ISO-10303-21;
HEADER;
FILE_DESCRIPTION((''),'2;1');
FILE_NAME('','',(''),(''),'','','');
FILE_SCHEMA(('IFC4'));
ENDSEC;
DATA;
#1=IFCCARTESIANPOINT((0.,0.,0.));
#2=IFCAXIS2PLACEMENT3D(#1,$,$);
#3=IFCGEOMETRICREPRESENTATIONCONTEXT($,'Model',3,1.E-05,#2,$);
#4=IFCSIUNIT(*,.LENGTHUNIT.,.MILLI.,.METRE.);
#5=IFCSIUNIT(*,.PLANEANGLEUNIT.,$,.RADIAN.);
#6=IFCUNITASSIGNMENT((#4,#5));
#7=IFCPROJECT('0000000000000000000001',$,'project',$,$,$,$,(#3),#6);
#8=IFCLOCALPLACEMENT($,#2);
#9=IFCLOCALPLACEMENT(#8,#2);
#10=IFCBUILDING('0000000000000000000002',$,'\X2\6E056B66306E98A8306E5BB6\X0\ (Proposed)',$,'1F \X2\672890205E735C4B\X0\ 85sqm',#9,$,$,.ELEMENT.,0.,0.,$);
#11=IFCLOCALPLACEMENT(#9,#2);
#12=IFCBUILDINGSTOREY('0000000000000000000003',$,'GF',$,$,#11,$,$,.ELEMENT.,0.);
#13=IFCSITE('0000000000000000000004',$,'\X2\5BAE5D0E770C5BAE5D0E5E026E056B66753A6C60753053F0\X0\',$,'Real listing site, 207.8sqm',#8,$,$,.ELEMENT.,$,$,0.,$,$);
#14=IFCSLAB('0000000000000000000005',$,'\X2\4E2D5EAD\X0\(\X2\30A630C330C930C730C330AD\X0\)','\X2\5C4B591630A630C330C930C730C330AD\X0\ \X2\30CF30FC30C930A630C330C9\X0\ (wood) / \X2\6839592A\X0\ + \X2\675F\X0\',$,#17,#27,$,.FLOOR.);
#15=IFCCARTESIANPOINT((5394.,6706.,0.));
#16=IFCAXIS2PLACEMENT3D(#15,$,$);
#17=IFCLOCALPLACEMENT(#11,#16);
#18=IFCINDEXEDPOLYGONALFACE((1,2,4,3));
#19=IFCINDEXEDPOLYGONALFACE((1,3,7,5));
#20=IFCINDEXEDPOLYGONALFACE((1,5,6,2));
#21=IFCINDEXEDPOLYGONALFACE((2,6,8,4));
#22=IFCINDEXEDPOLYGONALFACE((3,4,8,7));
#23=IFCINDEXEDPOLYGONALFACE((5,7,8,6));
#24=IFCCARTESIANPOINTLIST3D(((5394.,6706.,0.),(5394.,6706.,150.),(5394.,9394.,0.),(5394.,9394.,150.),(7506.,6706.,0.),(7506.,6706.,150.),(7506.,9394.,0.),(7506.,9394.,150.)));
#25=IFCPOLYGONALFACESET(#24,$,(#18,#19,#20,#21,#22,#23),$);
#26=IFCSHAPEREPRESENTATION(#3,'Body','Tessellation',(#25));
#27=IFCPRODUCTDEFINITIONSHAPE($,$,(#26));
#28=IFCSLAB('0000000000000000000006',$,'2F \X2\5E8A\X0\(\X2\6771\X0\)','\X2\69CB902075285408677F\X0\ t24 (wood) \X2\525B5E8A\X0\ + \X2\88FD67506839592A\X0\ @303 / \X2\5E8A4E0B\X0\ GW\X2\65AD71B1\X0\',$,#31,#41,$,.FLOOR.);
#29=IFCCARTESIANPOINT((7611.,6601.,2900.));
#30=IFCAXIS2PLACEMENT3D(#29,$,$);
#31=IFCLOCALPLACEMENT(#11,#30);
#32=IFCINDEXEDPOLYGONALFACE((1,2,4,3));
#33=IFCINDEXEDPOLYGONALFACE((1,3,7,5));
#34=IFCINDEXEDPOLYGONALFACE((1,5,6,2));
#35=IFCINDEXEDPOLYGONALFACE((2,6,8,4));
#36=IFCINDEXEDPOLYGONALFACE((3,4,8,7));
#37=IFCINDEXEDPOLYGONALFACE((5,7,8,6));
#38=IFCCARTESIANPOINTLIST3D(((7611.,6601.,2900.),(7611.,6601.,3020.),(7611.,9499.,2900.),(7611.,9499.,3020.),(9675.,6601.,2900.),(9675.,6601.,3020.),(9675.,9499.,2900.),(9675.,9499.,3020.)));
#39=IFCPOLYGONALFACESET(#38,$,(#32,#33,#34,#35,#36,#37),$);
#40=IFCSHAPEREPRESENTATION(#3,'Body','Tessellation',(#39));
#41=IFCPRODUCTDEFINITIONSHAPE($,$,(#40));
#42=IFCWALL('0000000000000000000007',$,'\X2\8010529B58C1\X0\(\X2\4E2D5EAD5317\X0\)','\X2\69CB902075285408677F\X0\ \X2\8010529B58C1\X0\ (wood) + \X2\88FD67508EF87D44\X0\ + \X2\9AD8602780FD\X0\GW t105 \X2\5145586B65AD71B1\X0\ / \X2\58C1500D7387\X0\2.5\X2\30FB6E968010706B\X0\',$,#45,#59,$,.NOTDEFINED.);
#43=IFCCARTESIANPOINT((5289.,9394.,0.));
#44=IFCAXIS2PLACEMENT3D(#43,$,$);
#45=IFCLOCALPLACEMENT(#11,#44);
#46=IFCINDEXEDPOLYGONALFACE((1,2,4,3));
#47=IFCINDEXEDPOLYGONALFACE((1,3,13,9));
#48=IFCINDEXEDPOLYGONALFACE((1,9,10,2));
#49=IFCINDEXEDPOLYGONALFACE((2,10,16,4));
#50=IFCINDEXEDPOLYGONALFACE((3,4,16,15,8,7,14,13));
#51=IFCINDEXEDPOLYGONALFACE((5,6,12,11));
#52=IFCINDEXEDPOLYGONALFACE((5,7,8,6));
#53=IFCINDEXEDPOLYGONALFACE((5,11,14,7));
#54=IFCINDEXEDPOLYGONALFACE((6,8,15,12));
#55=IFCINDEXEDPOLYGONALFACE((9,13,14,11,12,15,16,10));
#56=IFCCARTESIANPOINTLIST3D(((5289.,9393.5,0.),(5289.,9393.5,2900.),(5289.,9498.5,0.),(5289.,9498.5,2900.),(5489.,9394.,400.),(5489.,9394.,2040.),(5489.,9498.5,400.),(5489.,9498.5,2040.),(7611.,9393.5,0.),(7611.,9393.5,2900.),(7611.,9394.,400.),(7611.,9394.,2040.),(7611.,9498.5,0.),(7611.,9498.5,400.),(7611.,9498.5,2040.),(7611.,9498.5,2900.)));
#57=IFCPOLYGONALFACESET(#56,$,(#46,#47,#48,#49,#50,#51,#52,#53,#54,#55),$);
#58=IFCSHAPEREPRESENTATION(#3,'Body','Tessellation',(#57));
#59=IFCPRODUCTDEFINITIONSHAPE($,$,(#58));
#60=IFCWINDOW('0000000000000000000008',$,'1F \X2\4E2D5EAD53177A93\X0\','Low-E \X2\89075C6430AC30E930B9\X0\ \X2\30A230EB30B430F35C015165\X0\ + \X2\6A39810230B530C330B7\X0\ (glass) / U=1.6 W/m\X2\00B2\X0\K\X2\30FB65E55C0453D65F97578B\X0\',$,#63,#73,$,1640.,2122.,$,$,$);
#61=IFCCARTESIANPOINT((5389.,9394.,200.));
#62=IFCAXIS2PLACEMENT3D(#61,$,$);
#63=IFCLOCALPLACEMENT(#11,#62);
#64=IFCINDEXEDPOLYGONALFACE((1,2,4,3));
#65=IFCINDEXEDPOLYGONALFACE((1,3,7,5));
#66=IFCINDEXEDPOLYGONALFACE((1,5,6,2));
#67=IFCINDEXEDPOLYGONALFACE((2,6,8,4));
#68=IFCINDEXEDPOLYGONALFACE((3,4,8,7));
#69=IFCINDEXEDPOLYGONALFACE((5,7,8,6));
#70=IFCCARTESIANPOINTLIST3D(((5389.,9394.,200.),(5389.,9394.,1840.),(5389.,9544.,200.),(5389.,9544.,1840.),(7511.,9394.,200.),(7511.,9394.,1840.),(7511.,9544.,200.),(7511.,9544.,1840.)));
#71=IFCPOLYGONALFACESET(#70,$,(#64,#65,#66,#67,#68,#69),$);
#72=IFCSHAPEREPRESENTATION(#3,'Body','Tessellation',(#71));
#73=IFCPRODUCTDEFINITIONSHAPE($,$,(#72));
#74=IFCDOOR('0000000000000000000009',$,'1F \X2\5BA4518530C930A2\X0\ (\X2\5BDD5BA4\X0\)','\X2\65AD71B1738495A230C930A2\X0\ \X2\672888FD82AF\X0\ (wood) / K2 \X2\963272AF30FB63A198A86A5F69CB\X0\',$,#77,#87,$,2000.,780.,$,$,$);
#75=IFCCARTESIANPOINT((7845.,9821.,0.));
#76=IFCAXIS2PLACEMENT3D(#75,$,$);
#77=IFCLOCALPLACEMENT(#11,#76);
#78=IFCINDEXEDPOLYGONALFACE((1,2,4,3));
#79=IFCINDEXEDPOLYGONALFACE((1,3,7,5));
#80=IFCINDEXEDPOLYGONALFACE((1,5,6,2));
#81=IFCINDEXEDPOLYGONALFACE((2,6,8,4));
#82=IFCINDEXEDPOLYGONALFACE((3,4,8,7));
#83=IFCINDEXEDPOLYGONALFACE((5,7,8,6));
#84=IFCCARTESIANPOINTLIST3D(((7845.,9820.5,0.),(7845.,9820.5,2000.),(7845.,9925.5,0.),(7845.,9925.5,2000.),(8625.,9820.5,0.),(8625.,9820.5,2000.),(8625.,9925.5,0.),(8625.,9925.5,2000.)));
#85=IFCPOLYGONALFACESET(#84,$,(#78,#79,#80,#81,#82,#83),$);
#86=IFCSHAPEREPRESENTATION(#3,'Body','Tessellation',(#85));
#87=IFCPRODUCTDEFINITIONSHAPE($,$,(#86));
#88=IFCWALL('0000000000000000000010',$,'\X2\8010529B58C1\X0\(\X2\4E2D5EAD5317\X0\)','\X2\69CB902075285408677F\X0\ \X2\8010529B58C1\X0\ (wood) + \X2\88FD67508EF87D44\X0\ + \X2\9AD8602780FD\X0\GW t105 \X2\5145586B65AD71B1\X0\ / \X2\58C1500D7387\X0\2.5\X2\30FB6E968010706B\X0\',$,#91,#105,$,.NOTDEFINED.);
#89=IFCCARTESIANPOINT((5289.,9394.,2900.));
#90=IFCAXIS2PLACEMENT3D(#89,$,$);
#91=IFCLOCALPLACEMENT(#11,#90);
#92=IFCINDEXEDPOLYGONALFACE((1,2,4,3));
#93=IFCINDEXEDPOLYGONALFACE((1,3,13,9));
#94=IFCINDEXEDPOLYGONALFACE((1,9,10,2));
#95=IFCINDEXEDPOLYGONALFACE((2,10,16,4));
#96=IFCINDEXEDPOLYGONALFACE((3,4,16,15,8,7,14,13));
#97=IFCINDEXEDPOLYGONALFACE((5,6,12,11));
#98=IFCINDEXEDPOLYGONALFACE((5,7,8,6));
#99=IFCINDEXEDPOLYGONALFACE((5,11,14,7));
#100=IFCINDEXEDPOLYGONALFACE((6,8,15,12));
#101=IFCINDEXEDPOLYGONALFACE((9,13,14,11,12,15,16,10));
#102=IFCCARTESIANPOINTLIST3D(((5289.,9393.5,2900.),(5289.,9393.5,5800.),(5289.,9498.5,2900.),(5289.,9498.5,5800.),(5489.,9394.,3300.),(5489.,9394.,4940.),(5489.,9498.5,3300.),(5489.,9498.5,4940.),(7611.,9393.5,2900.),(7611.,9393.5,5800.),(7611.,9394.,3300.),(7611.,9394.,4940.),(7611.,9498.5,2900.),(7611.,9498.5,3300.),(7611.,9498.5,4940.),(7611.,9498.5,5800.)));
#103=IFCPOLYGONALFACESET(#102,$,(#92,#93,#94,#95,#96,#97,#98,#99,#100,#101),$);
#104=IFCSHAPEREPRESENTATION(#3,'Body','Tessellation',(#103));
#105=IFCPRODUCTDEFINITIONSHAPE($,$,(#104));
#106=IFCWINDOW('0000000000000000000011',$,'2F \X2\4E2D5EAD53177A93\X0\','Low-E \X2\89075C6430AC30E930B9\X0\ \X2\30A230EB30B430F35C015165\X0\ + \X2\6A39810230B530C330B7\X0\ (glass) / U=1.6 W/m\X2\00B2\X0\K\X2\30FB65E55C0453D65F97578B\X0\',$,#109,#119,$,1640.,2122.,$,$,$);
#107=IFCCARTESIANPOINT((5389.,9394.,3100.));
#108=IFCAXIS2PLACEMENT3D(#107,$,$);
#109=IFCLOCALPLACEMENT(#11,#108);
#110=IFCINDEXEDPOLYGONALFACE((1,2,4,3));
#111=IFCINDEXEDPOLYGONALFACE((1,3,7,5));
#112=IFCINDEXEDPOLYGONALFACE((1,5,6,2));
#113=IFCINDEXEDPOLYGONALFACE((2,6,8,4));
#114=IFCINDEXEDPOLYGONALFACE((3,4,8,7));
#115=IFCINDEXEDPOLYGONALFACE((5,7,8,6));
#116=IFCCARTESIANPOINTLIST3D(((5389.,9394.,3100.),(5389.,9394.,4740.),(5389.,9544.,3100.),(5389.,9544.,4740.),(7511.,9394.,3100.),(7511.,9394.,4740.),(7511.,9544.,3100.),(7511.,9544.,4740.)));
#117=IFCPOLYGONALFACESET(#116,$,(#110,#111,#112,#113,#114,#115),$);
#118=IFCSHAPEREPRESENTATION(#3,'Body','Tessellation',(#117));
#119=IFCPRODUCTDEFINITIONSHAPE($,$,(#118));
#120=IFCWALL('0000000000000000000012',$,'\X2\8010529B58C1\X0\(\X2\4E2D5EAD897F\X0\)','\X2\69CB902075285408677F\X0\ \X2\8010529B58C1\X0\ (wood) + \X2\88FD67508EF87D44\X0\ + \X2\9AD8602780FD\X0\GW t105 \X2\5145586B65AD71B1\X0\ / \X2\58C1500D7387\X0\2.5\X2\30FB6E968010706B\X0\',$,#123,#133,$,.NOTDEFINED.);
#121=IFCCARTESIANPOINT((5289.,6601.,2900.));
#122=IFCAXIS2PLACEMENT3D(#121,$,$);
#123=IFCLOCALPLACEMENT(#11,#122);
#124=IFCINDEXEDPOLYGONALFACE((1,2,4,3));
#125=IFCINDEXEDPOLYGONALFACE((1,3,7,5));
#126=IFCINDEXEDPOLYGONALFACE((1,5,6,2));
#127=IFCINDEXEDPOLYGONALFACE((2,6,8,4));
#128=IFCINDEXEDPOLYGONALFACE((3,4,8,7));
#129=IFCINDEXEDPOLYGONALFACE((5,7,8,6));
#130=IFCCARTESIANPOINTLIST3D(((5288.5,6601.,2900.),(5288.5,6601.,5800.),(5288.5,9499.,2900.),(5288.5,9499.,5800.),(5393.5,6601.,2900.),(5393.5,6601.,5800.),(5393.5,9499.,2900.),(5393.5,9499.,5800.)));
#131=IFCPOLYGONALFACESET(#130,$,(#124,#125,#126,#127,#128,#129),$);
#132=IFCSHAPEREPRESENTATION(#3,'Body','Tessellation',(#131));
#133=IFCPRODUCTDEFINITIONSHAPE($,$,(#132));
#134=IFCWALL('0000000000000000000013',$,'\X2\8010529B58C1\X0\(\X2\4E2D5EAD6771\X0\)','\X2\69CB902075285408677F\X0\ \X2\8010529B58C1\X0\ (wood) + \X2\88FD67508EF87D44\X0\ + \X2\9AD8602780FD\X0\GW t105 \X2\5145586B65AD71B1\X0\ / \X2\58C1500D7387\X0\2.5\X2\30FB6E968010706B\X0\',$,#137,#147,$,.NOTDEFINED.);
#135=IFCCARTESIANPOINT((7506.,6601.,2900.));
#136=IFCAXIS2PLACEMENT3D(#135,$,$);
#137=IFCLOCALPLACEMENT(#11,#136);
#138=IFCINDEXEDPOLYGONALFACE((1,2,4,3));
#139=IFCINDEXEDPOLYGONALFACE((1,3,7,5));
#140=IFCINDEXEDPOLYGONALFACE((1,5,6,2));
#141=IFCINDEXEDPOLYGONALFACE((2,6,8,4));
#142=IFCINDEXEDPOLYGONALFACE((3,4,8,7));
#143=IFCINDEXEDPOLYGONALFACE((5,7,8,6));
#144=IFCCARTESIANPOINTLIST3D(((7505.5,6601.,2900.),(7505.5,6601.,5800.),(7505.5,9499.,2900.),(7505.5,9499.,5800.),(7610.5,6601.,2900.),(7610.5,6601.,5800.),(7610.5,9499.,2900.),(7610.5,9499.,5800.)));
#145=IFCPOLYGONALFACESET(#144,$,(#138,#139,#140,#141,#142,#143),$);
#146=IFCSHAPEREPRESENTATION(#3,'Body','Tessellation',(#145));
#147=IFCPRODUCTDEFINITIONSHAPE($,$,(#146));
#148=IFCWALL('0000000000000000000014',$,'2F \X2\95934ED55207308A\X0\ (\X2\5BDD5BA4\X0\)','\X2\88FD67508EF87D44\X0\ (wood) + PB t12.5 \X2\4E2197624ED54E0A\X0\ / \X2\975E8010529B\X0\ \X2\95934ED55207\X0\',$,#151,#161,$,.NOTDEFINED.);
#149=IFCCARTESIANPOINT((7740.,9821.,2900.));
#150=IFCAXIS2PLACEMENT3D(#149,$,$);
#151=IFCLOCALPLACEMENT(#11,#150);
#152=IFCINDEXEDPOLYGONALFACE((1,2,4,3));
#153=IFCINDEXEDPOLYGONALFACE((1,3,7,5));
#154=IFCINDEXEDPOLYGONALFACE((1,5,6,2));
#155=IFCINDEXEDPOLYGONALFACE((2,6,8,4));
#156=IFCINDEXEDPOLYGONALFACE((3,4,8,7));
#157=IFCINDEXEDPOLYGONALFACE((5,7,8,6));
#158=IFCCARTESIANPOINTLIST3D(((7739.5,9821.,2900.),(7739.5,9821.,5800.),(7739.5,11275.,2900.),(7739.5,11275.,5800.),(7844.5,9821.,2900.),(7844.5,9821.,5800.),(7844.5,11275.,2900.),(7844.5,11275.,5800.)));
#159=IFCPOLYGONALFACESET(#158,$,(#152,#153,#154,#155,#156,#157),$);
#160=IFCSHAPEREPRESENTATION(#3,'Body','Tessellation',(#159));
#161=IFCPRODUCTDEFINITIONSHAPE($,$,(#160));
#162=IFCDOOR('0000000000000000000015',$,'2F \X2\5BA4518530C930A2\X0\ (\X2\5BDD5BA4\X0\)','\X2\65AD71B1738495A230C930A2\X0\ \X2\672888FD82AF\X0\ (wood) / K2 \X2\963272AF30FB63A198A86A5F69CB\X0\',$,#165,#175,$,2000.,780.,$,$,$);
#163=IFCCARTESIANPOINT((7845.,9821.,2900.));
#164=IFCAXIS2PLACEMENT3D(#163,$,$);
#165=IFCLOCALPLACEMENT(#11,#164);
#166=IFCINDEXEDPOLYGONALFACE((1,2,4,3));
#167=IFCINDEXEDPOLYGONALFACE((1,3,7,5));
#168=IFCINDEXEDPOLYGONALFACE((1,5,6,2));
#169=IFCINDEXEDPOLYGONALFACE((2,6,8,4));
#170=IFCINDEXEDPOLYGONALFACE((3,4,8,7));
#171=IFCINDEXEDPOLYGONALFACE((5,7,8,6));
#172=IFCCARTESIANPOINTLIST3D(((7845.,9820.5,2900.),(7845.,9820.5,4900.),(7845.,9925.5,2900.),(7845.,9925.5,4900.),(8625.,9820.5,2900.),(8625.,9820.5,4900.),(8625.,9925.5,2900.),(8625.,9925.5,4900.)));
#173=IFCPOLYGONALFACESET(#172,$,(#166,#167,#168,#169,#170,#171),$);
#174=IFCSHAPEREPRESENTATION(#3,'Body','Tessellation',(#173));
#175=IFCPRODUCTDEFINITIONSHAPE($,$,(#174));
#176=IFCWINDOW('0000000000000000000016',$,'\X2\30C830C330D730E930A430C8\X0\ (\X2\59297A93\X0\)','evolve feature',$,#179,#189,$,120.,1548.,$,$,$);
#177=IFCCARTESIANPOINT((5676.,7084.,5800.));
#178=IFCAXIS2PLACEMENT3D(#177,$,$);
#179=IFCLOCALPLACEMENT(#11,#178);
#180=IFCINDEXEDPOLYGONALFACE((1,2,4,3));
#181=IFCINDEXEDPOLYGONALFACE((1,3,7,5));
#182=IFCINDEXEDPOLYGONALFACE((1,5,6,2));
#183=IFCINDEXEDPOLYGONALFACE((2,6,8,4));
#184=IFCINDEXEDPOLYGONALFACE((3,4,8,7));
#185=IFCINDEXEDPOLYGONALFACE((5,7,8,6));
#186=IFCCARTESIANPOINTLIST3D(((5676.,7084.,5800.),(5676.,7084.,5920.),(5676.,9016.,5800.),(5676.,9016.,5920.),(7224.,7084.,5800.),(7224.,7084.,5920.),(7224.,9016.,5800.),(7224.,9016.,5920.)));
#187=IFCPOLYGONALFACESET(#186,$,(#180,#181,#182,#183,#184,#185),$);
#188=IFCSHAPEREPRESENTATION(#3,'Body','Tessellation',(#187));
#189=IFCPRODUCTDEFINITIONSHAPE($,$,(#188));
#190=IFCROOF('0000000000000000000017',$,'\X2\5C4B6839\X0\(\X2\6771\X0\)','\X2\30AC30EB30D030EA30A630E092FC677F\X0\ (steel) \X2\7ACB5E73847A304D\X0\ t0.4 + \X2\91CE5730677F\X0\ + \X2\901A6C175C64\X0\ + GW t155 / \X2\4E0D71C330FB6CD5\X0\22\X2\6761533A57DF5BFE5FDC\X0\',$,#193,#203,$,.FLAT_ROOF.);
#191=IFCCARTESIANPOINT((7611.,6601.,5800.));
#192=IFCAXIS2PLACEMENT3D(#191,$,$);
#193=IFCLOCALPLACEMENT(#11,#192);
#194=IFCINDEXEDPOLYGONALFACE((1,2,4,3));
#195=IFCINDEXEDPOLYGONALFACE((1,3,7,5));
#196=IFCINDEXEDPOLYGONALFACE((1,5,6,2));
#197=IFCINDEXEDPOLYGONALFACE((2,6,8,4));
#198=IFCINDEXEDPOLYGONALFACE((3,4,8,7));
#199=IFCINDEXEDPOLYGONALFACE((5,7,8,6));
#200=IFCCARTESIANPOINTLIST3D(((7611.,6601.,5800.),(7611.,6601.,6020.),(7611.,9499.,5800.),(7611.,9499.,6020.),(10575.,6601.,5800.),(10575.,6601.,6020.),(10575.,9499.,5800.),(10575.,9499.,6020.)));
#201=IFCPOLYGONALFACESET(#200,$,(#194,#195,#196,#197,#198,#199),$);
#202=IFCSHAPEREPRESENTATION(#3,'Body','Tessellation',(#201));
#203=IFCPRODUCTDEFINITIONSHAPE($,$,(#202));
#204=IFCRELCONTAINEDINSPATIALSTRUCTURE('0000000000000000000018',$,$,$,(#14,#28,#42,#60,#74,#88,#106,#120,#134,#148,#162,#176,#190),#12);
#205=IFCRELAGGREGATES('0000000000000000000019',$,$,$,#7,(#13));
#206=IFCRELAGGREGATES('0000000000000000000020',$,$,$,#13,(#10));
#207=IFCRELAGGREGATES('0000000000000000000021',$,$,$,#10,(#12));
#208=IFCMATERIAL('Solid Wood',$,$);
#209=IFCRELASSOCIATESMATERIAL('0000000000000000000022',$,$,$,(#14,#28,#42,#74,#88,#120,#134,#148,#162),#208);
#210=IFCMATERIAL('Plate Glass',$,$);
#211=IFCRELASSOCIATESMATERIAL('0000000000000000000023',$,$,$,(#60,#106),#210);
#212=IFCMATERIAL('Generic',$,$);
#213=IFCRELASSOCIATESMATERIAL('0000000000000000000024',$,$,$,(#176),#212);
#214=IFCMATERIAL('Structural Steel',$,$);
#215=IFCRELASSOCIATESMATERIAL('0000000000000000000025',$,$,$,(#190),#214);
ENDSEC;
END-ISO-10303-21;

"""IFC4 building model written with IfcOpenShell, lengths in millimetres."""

from ifc_helpers import new_model, si_unit, frame, frame_2d, origin, place, context, project, spatial, rectangle, extrude, material, element, fill, save


model = new_model("IFC4")

# Units and contexts
model_context = context("Model", 3, precision=1e-05, world=origin())
ifc_project = project(units=[si_unit("LENGTHUNIT", "METRE", prefix="MILLI"), si_unit("PLANEANGLEUNIT", "RADIAN")], contexts=[model_context])

# Site, building, storey
site_placement = place(None, origin())
site = spatial("IfcSite", under=ifc_project, at=site_placement, Name="宮崎県宮崎市清武町池田台", ObjectType="Real listing site, 207.8sqm", CompositionType="ELEMENT", RefElevation=0.0)
building_placement = place(site_placement, origin())
building = spatial("IfcBuilding", under=site, at=building_placement, Name="清武の風の家 (Proposed)", ObjectType="1F 木造平屋 85sqm", CompositionType="ELEMENT", ElevationOfRefHeight=0.0, ElevationOfTerrain=0.0)
storey_placement = place(building_placement, origin())
storey = spatial("IfcBuildingStorey", under=building, at=storey_placement, Name="GF", CompositionType="ELEMENT", Elevation=0.0)

# Slabs
ifc_material_1 = material(Name="Solid Wood")
slab_1_placement = place(storey_placement, frame((5394.0, 6706.0, 0.0)))
element("IfcSlab", 1, at=slab_1_placement, inside=storey, material=ifc_material_1, Name="中庭(ウッドデッキ)", Description="屋外ウッドデッキ ハードウッド (wood) / 根太 + 束", PredefinedType="FLOOR", context=model_context, shape_type="SweptSolid", body=[
    extrude(rectangle(XDim=2112.0, YDim=2688.0, at=frame_2d((1056.0, 1344.0))), frame((5394.0, 6706.0, 0.0)), (0.0, 0.0, 1.0), 150.0),
])
slab_2_placement = place(storey_placement, frame((7611.0, 6601.0, 2900.0)))
element("IfcSlab", 2, at=slab_2_placement, inside=storey, material=ifc_material_1, Name="2F 床(東)", Description="構造用合板 t24 (wood) 剛床 + 製材根太 @303 / 床下 GW断熱", PredefinedType="FLOOR", context=model_context, shape_type="SweptSolid", body=[
    extrude(rectangle(XDim=2064.0, YDim=2898.0, at=frame_2d((1032.0, 1449.0))), frame((7611.0, 6601.0, 2900.0)), (0.0, 0.0, 1.0), 120.0),
])

# Wall, opening, window
wall_1_placement = place(storey_placement, frame((5289.0, 9394.0, 0.0)))
wall_1 = element("IfcWall", 3, at=wall_1_placement, inside=storey, material=ifc_material_1, Name="耐力壁(中庭北)", Description="構造用合板 耐力壁 (wood) + 製材軸組 + 高性能GW t105 充填断熱 / 壁倍率2.5・準耐火", PredefinedType="NOTDEFINED", context=model_context, shape_type="SweptSolid", body=[
    extrude(rectangle(XDim=2322.0, YDim=105.0, at=frame_2d((1161.0, 52.0))), frame((5289.0, 9394.0, 0.0)), (0.0, 0.0, 1.0), 2900.0),
])
opening_1_placement = place(storey_placement, frame((5389.0, 9394.0, 200.0)))
opening_1 = element("IfcOpeningElement", 4, at=opening_1_placement, cuts=wall_1, PredefinedType="NOTDEFINED", context=model_context, shape_type="SweptSolid", body=[
    extrude(rectangle(XDim=2122.0, YDim=150.0, at=frame_2d((1061.0, 75.0))), frame((5389.0, 9394.0, 200.0)), (0.0, 0.0, 1.0), 1640.0),
])
ifc_material_2 = material(Name="Plate Glass")
window_1_placement = place(storey_placement, frame((5389.0, 9394.0, 200.0)))
window_1 = element("IfcWindow", 5, at=window_1_placement, inside=storey, material=ifc_material_2, Name="1F 中庭北窓", Description="Low-E 複層ガラス アルゴン封入 + 樹脂サッシ (glass) / U=1.6 W/m²K・日射取得型", OverallHeight=1640.0, OverallWidth=2122.0, context=model_context, shape_type="SweptSolid", body=[
    extrude(rectangle(XDim=2122.0, YDim=150.0, at=frame_2d((1061.0, 75.0))), frame((5389.0, 9394.0, 200.0)), (0.0, 0.0, 1.0), 1640.0),
])
fill(opening_1, window_1)

# Door
door_1_placement = place(storey_placement, frame((7845.0, 9821.0, 0.0)))
element("IfcDoor", 6, at=door_1_placement, inside=storey, material=ifc_material_1, Name="1F 室内ドア (寝室)", Description="断熱玄関ドア 木製芯 (wood) / K2 防犯・採風機構", OverallHeight=2000.0, OverallWidth=780.0, context=model_context, shape_type="SweptSolid", body=[
    extrude(rectangle(XDim=780.0, YDim=105.0, at=frame_2d((390.0, 52.0))), frame((7845.0, 9821.0, 0.0)), (0.0, 0.0, 1.0), 2000.0),
])

# Wall, opening, window
wall_2_placement = place(storey_placement, frame((5289.0, 9394.0, 2900.0)))
wall_2 = element("IfcWall", 7, at=wall_2_placement, inside=storey, material=ifc_material_1, Name="耐力壁(中庭北)", Description="構造用合板 耐力壁 (wood) + 製材軸組 + 高性能GW t105 充填断熱 / 壁倍率2.5・準耐火", PredefinedType="NOTDEFINED", context=model_context, shape_type="SweptSolid", body=[
    extrude(rectangle(XDim=2322.0, YDim=105.0, at=frame_2d((1161.0, 52.0))), frame((5289.0, 9394.0, 2900.0)), (0.0, 0.0, 1.0), 2900.0),
])
opening_2_placement = place(storey_placement, frame((5389.0, 9394.0, 3100.0)))
opening_2 = element("IfcOpeningElement", 8, at=opening_2_placement, cuts=wall_2, PredefinedType="NOTDEFINED", context=model_context, shape_type="SweptSolid", body=[
    extrude(rectangle(XDim=2122.0, YDim=150.0, at=frame_2d((1061.0, 75.0))), frame((5389.0, 9394.0, 3100.0)), (0.0, 0.0, 1.0), 1640.0),
])
window_2_placement = place(storey_placement, frame((5389.0, 9394.0, 3100.0)))
window_2 = element("IfcWindow", 9, at=window_2_placement, inside=storey, material=ifc_material_2, Name="2F 中庭北窓", Description="Low-E 複層ガラス アルゴン封入 + 樹脂サッシ (glass) / U=1.6 W/m²K・日射取得型", OverallHeight=1640.0, OverallWidth=2122.0, context=model_context, shape_type="SweptSolid", body=[
    extrude(rectangle(XDim=2122.0, YDim=150.0, at=frame_2d((1061.0, 75.0))), frame((5389.0, 9394.0, 3100.0)), (0.0, 0.0, 1.0), 1640.0),
])
fill(opening_2, window_2)

# Walls
wall_3_placement = place(storey_placement, frame((5289.0, 6601.0, 2900.0)))
element("IfcWall", 10, at=wall_3_placement, inside=storey, material=ifc_material_1, Name="耐力壁(中庭西)", Description="構造用合板 耐力壁 (wood) + 製材軸組 + 高性能GW t105 充填断熱 / 壁倍率2.5・準耐火", PredefinedType="NOTDEFINED", context=model_context, shape_type="SweptSolid", body=[
    extrude(rectangle(XDim=105.0, YDim=2898.0, at=frame_2d((52.0, 1449.0))), frame((5289.0, 6601.0, 2900.0)), (0.0, 0.0, 1.0), 2900.0),
])
wall_4_placement = place(storey_placement, frame((7506.0, 6601.0, 2900.0)))
element("IfcWall", 11, at=wall_4_placement, inside=storey, material=ifc_material_1, Name="耐力壁(中庭東)", Description="構造用合板 耐力壁 (wood) + 製材軸組 + 高性能GW t105 充填断熱 / 壁倍率2.5・準耐火", PredefinedType="NOTDEFINED", context=model_context, shape_type="SweptSolid", body=[
    extrude(rectangle(XDim=105.0, YDim=2898.0, at=frame_2d((52.0, 1449.0))), frame((7506.0, 6601.0, 2900.0)), (0.0, 0.0, 1.0), 2900.0),
])
wall_5_placement = place(storey_placement, frame((7740.0, 9821.0, 2900.0)))
element("IfcWall", 12, at=wall_5_placement, inside=storey, material=ifc_material_1, Name="2F 間仕切り (寝室)", Description="製材軸組 (wood) + PB t12.5 両面仕上 / 非耐力 間仕切", PredefinedType="NOTDEFINED", context=model_context, shape_type="SweptSolid", body=[
    extrude(rectangle(XDim=105.0, YDim=1454.0, at=frame_2d((52.0, 727.0))), frame((7740.0, 9821.0, 2900.0)), (0.0, 0.0, 1.0), 2900.0),
])

# Door
door_2_placement = place(storey_placement, frame((7845.0, 9821.0, 2900.0)))
element("IfcDoor", 13, at=door_2_placement, inside=storey, material=ifc_material_1, Name="2F 室内ドア (寝室)", Description="断熱玄関ドア 木製芯 (wood) / K2 防犯・採風機構", OverallHeight=2000.0, OverallWidth=780.0, context=model_context, shape_type="SweptSolid", body=[
    extrude(rectangle(XDim=780.0, YDim=105.0, at=frame_2d((390.0, 52.0))), frame((7845.0, 9821.0, 2900.0)), (0.0, 0.0, 1.0), 2000.0),
])

# Window
ifc_material_3 = material(Name="Generic")
window_3_placement = place(storey_placement, frame((5676.0, 7084.0, 5800.0)))
element("IfcWindow", 14, at=window_3_placement, inside=storey, material=ifc_material_3, Name="トップライト (天窓)", Description="evolve feature", OverallHeight=120.0, OverallWidth=1548.0, context=model_context, shape_type="SweptSolid", body=[
    extrude(rectangle(XDim=1548.0, YDim=1932.0, at=frame_2d((774.0, 966.0))), frame((5676.0, 7084.0, 5800.0)), (0.0, 0.0, 1.0), 120.0),
])

# Roof
ifc_material_4 = material(Name="Structural Steel")
roof_placement = place(storey_placement, frame((7611.0, 6601.0, 5800.0)))
element("IfcRoof", 15, at=roof_placement, inside=storey, material=ifc_material_4, Name="屋根(東)", Description="ガルバリウム鋼板 (steel) 立平葺き t0.4 + 野地板 + 通気層 + GW t155 / 不燃・法22条区域対応", PredefinedType="FLAT_ROOF", context=model_context, shape_type="SweptSolid", body=[
    extrude(rectangle(XDim=2964.0, YDim=2898.0, at=frame_2d((1482.0, 1449.0))), frame((7611.0, 6601.0, 5800.0)), (0.0, 0.0, 1.0), 220.0),
])

save(model, "model.ifc")
